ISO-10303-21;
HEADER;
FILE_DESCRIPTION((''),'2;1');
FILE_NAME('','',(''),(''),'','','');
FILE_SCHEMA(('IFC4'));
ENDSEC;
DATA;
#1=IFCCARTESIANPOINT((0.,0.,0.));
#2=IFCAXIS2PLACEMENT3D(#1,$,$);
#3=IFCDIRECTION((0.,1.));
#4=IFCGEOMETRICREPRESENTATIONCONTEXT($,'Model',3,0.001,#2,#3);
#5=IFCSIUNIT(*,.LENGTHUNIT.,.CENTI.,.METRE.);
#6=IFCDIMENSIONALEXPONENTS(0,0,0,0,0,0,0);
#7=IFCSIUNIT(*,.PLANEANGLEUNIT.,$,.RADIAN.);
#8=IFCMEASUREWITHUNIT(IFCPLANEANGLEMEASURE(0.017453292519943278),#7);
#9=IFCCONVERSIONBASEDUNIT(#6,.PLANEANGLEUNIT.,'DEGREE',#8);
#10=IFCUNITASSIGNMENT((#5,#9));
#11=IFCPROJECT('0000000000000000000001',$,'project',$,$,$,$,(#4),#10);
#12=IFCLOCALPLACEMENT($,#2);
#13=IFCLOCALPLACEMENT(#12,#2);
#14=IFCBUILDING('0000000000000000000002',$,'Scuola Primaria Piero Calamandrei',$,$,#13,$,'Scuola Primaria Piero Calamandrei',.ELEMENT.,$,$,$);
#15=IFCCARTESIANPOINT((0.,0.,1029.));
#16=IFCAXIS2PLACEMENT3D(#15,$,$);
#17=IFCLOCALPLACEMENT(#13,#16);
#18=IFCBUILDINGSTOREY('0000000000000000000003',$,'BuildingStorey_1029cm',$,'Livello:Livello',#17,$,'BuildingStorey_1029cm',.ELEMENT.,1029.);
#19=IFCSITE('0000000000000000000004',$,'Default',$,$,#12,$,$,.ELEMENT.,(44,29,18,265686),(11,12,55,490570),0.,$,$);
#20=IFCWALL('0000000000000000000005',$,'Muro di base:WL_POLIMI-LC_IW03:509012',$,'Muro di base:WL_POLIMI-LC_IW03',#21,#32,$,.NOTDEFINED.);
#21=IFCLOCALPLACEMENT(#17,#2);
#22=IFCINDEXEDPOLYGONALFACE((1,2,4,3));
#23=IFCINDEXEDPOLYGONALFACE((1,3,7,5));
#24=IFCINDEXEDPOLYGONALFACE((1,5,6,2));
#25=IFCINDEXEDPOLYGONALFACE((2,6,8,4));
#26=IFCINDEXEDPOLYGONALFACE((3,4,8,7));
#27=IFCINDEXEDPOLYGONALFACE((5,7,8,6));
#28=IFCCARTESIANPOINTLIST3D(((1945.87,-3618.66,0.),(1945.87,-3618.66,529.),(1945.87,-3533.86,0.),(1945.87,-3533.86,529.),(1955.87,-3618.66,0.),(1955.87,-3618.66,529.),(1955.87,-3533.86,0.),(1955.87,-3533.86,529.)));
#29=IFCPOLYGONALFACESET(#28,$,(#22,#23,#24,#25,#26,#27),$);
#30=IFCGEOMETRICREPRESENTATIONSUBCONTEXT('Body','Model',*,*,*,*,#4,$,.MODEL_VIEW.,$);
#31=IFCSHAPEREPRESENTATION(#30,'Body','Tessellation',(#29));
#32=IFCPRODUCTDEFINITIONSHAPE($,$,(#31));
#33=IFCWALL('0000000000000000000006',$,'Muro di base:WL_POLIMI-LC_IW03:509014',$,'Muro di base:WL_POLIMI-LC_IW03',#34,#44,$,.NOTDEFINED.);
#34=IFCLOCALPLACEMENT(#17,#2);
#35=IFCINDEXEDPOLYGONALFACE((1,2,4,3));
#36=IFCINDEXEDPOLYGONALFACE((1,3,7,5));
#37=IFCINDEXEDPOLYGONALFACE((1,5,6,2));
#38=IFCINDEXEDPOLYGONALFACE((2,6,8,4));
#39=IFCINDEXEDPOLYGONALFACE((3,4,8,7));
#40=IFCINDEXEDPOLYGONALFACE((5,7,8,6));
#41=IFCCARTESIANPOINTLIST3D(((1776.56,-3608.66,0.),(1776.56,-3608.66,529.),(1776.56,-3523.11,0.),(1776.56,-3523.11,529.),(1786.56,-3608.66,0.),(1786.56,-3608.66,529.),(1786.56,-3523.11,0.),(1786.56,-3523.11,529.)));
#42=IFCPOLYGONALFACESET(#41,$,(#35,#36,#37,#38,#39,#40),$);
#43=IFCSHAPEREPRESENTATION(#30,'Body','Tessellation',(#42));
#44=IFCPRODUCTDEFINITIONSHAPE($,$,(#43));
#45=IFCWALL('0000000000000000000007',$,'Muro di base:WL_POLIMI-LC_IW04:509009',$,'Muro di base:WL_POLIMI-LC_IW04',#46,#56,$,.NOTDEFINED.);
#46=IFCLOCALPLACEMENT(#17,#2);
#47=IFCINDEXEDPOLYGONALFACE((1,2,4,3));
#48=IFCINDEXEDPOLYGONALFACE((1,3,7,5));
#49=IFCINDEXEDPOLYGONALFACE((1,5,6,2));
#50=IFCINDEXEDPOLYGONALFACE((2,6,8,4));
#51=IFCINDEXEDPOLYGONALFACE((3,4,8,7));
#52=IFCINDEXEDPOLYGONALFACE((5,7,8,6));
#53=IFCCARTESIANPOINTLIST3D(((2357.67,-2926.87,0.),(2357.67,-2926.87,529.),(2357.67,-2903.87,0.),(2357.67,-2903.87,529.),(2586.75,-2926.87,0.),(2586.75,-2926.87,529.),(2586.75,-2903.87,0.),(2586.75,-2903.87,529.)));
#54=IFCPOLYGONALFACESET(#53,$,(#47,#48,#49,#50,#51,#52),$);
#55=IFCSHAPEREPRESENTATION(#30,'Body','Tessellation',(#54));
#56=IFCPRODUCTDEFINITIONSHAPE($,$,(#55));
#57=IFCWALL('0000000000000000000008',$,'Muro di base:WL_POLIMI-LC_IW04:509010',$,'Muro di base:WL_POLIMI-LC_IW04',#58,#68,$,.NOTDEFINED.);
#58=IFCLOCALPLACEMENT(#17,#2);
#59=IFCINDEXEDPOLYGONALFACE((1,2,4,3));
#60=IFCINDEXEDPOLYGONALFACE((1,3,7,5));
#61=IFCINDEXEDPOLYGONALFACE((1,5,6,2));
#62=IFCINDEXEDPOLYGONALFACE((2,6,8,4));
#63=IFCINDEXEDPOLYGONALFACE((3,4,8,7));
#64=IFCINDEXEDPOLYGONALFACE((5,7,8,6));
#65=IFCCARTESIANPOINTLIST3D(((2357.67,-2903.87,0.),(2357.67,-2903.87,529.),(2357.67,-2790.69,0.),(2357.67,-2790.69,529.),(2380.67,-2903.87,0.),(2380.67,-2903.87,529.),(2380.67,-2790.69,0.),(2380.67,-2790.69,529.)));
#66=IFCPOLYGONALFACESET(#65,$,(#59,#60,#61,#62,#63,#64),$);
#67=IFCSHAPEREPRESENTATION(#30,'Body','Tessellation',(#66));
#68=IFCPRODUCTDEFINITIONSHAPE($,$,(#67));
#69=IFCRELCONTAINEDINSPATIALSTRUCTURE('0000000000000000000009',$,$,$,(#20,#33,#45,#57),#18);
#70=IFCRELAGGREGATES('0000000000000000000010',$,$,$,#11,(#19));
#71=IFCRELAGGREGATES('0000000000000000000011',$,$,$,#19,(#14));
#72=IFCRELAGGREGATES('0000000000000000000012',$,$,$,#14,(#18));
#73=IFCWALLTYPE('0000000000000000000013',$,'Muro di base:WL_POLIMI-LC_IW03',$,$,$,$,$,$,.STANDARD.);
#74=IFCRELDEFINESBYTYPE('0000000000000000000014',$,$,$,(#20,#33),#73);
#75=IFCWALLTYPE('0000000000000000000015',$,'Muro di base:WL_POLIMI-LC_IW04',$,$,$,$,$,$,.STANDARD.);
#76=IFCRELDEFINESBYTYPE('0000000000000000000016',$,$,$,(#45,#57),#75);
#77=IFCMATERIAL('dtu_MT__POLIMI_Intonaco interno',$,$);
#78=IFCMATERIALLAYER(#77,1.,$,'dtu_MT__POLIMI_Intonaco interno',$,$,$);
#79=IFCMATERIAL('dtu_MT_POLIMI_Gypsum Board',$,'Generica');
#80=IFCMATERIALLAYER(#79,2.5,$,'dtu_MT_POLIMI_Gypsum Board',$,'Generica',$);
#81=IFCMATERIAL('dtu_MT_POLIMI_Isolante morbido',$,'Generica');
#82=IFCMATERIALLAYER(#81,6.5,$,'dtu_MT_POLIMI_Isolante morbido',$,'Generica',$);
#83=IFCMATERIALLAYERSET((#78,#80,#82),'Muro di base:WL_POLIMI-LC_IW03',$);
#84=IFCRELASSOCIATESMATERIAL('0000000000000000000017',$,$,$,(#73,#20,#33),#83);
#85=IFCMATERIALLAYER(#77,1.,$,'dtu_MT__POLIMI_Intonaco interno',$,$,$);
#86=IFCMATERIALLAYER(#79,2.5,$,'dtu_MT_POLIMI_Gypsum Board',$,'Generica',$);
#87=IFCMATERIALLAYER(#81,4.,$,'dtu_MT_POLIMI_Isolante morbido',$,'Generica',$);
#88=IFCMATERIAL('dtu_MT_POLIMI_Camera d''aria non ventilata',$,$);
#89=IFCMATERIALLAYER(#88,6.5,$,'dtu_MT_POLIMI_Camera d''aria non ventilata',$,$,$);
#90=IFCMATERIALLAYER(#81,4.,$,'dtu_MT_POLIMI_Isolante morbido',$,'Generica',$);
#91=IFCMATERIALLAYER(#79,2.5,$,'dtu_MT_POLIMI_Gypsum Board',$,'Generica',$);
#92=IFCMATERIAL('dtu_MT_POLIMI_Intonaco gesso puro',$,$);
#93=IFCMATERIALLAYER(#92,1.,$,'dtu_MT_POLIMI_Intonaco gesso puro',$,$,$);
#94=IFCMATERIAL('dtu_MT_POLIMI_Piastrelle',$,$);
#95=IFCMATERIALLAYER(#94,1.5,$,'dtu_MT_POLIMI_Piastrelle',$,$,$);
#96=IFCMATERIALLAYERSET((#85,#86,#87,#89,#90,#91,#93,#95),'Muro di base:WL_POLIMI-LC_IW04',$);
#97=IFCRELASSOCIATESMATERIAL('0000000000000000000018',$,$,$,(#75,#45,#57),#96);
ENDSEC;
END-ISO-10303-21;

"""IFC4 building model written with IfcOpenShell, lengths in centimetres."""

from ifc_helpers import new_model, entity, si_unit, converted_unit, direction, frame, frame_2d, origin, place, context, subcontext, project, spatial, rectangle, extrude, material, layer, layer_set, layer_usage, type_object, element, save


model = new_model("IFC4")

# Units and contexts
model_context = context("Model", 3, precision=0.001, world=origin(), true_north=direction((0.0, 1.0)))
body_context = subcontext(model_context, "Body", "Model", "MODEL_VIEW")
ifc_project = project(units=[si_unit("LENGTHUNIT", "METRE", prefix="CENTI"), converted_unit("PLANEANGLEUNIT", "DEGREE", entity("IfcPlaneAngleMeasure", 0.017453292519943278), si_unit("PLANEANGLEUNIT", "RADIAN"), dimensions=[0, 0, 0, 0, 0, 0, 0])], contexts=[model_context])

# Site, building, storey
site_placement = place(None, origin())
site = spatial("IfcSite", under=ifc_project, at=site_placement, Name="Default", CompositionType="ELEMENT", RefLatitude=(44, 29, 18, 265686), RefLongitude=(11, 12, 55, 490570), RefElevation=0.0)
building_placement = place(site_placement, origin())
building = spatial("IfcBuilding", under=site, at=building_placement, Name="Scuola Primaria Piero Calamandrei", LongName="Scuola Primaria Piero Calamandrei", CompositionType="ELEMENT")
storey_placement = place(building_placement, frame((0.0, 0.0, 1029.0)))
storey = spatial("IfcBuildingStorey", under=building, at=storey_placement, Name="BuildingStorey_1029cm", ObjectType="Livello:Livello", LongName="BuildingStorey_1029cm", CompositionType="ELEMENT", Elevation=1029.0)

# Shared definitions
ifc_material_1 = material(Name="dtu_MT_POLIMI_Isolante morbido", Category="Generica")
ifc_material_2 = material(Name="dtu_MT_POLIMI_Gypsum Board", Category="Generica")
ifc_material_3 = material(Name="dtu_MT__POLIMI_Intonaco interno")
ifc_material_4 = material(Name="dtu_MT_POLIMI_Camera d'aria non ventilata")
ifc_material_5 = material(Name="dtu_MT_POLIMI_Intonaco gesso puro")

# Walls
ifc_layer_1 = layer(ifc_material_3, 1.0, Name="dtu_MT__POLIMI_Intonaco interno")
ifc_layer_2 = layer(ifc_material_2, 2.5, Name="dtu_MT_POLIMI_Gypsum Board", Category="Generica")
ifc_layer_3 = layer(ifc_material_1, 6.5, Name="dtu_MT_POLIMI_Isolante morbido", Category="Generica")
ifc_layer_set_1 = layer_set([ifc_layer_1, ifc_layer_2, ifc_layer_3], Name="Muro di base:WL_POLIMI-LC_IW03")
wall_type_1 = type_object("IfcWallType", Name="Muro di base:WL_POLIMI-LC_IW03", PredefinedType="STANDARD", material=ifc_layer_set_1)
ifc_layer_usage_1 = layer_usage(ifc_layer_set_1, "AXIS2", "NEGATIVE", 5.0)
wall_1_placement = place(storey_placement, frame((1950.87, -3618.66, 0.0), z_axis=(0.0, 0.0, 1.0), x_axis=(0.0, 1.0, 0.0)))
element("IfcWall", 1, at=wall_1_placement, inside=storey, type_object=wall_type_1, material=ifc_layer_usage_1, Name="Muro di base:WL_POLIMI-LC_IW03:509012", ObjectType="Muro di base:WL_POLIMI-LC_IW03", PredefinedType="NOTDEFINED", context=body_context, shape_type="SweptSolid", body=[
    extrude(rectangle(XDim=84.8, YDim=10.0, at=frame_2d((42.4, 0.0), x_axis=(-1.0, 0.0))), origin(), (0.0, 0.0, 1.0), 529.0),
])
ifc_layer_usage_2 = layer_usage(ifc_layer_set_1, "AXIS2", "NEGATIVE", 5.0)
wall_2_placement = place(storey_placement, frame((1781.56, -3523.11, 0.0), z_axis=(0.0, 0.0, 1.0), x_axis=(0.0, -1.0, 0.0)))
element("IfcWall", 2, at=wall_2_placement, inside=storey, type_object=wall_type_1, material=ifc_layer_usage_2, Name="Muro di base:WL_POLIMI-LC_IW03:509014", ObjectType="Muro di base:WL_POLIMI-LC_IW03", PredefinedType="NOTDEFINED", context=body_context, shape_type="SweptSolid", body=[
    extrude(rectangle(XDim=85.55, YDim=10.0, at=frame_2d((42.78, 0.0), x_axis=(-1.0, 0.0))), origin(), (0.0, 0.0, 1.0), 529.0),
])
ifc_layer_4 = layer(ifc_material_3, 1.0, Name="dtu_MT__POLIMI_Intonaco interno")
ifc_layer_5 = layer(ifc_material_2, 2.5, Name="dtu_MT_POLIMI_Gypsum Board", Category="Generica")
ifc_layer_6 = layer(ifc_material_1, 4.0, Name="dtu_MT_POLIMI_Isolante morbido", Category="Generica")
ifc_layer_7 = layer(ifc_material_4, 6.5, Name="dtu_MT_POLIMI_Camera d'aria non ventilata")
ifc_layer_8 = layer(ifc_material_1, 4.0, Name="dtu_MT_POLIMI_Isolante morbido", Category="Generica")
ifc_layer_9 = layer(ifc_material_2, 2.5, Name="dtu_MT_POLIMI_Gypsum Board", Category="Generica")
ifc_layer_10 = layer(ifc_material_5, 1.0, Name="dtu_MT_POLIMI_Intonaco gesso puro")
ifc_material_6 = material(Name="dtu_MT_POLIMI_Piastrelle")
ifc_layer_11 = layer(ifc_material_6, 1.5, Name="dtu_MT_POLIMI_Piastrelle")
ifc_layer_set_2 = layer_set([ifc_layer_4, ifc_layer_5, ifc_layer_6, ifc_layer_7, ifc_layer_8, ifc_layer_9, ifc_layer_10, ifc_layer_11], Name="Muro di base:WL_POLIMI-LC_IW04")
ifc_layer_usage_3 = layer_usage(ifc_layer_set_2, "AXIS2", "NEGATIVE", 11.5)
wall_type_2 = type_object("IfcWallType", Name="Muro di base:WL_POLIMI-LC_IW04", PredefinedType="STANDARD", material=ifc_layer_set_2)
wall_3_placement = place(storey_placement, frame((2357.67, -2915.37, 0.0)))
element("IfcWall", 3, at=wall_3_placement, inside=storey, type_object=wall_type_2, material=ifc_layer_usage_3, Name="Muro di base:WL_POLIMI-LC_IW04:509009", ObjectType="Muro di base:WL_POLIMI-LC_IW04", PredefinedType="NOTDEFINED", context=body_context, shape_type="SweptSolid", body=[
    extrude(rectangle(XDim=229.07, YDim=23.0, at=frame_2d((114.54, 0.0), x_axis=(-1.0, 0.0))), origin(), (0.0, 0.0, 1.0), 529.0),
])
ifc_layer_usage_4 = layer_usage(ifc_layer_set_2, "AXIS2", "NEGATIVE", 11.5)
wall_4_placement = place(storey_placement, frame((2369.17, -2790.69, 0.0), z_axis=(0.0, 0.0, 1.0), x_axis=(0.0, -1.0, 0.0)))
element("IfcWall", 4, at=wall_4_placement, inside=storey, type_object=wall_type_2, material=ifc_layer_usage_4, Name="Muro di base:WL_POLIMI-LC_IW04:509010", ObjectType="Muro di base:WL_POLIMI-LC_IW04", PredefinedType="NOTDEFINED", context=body_context, shape_type="SweptSolid", body=[
    extrude(rectangle(XDim=113.18, YDim=23.0, at=frame_2d((56.59, 0.0), x_axis=(-1.0, 0.0))), origin(), (0.0, 0.0, 1.0), 529.0),
])

save(model, "model.ifc")
